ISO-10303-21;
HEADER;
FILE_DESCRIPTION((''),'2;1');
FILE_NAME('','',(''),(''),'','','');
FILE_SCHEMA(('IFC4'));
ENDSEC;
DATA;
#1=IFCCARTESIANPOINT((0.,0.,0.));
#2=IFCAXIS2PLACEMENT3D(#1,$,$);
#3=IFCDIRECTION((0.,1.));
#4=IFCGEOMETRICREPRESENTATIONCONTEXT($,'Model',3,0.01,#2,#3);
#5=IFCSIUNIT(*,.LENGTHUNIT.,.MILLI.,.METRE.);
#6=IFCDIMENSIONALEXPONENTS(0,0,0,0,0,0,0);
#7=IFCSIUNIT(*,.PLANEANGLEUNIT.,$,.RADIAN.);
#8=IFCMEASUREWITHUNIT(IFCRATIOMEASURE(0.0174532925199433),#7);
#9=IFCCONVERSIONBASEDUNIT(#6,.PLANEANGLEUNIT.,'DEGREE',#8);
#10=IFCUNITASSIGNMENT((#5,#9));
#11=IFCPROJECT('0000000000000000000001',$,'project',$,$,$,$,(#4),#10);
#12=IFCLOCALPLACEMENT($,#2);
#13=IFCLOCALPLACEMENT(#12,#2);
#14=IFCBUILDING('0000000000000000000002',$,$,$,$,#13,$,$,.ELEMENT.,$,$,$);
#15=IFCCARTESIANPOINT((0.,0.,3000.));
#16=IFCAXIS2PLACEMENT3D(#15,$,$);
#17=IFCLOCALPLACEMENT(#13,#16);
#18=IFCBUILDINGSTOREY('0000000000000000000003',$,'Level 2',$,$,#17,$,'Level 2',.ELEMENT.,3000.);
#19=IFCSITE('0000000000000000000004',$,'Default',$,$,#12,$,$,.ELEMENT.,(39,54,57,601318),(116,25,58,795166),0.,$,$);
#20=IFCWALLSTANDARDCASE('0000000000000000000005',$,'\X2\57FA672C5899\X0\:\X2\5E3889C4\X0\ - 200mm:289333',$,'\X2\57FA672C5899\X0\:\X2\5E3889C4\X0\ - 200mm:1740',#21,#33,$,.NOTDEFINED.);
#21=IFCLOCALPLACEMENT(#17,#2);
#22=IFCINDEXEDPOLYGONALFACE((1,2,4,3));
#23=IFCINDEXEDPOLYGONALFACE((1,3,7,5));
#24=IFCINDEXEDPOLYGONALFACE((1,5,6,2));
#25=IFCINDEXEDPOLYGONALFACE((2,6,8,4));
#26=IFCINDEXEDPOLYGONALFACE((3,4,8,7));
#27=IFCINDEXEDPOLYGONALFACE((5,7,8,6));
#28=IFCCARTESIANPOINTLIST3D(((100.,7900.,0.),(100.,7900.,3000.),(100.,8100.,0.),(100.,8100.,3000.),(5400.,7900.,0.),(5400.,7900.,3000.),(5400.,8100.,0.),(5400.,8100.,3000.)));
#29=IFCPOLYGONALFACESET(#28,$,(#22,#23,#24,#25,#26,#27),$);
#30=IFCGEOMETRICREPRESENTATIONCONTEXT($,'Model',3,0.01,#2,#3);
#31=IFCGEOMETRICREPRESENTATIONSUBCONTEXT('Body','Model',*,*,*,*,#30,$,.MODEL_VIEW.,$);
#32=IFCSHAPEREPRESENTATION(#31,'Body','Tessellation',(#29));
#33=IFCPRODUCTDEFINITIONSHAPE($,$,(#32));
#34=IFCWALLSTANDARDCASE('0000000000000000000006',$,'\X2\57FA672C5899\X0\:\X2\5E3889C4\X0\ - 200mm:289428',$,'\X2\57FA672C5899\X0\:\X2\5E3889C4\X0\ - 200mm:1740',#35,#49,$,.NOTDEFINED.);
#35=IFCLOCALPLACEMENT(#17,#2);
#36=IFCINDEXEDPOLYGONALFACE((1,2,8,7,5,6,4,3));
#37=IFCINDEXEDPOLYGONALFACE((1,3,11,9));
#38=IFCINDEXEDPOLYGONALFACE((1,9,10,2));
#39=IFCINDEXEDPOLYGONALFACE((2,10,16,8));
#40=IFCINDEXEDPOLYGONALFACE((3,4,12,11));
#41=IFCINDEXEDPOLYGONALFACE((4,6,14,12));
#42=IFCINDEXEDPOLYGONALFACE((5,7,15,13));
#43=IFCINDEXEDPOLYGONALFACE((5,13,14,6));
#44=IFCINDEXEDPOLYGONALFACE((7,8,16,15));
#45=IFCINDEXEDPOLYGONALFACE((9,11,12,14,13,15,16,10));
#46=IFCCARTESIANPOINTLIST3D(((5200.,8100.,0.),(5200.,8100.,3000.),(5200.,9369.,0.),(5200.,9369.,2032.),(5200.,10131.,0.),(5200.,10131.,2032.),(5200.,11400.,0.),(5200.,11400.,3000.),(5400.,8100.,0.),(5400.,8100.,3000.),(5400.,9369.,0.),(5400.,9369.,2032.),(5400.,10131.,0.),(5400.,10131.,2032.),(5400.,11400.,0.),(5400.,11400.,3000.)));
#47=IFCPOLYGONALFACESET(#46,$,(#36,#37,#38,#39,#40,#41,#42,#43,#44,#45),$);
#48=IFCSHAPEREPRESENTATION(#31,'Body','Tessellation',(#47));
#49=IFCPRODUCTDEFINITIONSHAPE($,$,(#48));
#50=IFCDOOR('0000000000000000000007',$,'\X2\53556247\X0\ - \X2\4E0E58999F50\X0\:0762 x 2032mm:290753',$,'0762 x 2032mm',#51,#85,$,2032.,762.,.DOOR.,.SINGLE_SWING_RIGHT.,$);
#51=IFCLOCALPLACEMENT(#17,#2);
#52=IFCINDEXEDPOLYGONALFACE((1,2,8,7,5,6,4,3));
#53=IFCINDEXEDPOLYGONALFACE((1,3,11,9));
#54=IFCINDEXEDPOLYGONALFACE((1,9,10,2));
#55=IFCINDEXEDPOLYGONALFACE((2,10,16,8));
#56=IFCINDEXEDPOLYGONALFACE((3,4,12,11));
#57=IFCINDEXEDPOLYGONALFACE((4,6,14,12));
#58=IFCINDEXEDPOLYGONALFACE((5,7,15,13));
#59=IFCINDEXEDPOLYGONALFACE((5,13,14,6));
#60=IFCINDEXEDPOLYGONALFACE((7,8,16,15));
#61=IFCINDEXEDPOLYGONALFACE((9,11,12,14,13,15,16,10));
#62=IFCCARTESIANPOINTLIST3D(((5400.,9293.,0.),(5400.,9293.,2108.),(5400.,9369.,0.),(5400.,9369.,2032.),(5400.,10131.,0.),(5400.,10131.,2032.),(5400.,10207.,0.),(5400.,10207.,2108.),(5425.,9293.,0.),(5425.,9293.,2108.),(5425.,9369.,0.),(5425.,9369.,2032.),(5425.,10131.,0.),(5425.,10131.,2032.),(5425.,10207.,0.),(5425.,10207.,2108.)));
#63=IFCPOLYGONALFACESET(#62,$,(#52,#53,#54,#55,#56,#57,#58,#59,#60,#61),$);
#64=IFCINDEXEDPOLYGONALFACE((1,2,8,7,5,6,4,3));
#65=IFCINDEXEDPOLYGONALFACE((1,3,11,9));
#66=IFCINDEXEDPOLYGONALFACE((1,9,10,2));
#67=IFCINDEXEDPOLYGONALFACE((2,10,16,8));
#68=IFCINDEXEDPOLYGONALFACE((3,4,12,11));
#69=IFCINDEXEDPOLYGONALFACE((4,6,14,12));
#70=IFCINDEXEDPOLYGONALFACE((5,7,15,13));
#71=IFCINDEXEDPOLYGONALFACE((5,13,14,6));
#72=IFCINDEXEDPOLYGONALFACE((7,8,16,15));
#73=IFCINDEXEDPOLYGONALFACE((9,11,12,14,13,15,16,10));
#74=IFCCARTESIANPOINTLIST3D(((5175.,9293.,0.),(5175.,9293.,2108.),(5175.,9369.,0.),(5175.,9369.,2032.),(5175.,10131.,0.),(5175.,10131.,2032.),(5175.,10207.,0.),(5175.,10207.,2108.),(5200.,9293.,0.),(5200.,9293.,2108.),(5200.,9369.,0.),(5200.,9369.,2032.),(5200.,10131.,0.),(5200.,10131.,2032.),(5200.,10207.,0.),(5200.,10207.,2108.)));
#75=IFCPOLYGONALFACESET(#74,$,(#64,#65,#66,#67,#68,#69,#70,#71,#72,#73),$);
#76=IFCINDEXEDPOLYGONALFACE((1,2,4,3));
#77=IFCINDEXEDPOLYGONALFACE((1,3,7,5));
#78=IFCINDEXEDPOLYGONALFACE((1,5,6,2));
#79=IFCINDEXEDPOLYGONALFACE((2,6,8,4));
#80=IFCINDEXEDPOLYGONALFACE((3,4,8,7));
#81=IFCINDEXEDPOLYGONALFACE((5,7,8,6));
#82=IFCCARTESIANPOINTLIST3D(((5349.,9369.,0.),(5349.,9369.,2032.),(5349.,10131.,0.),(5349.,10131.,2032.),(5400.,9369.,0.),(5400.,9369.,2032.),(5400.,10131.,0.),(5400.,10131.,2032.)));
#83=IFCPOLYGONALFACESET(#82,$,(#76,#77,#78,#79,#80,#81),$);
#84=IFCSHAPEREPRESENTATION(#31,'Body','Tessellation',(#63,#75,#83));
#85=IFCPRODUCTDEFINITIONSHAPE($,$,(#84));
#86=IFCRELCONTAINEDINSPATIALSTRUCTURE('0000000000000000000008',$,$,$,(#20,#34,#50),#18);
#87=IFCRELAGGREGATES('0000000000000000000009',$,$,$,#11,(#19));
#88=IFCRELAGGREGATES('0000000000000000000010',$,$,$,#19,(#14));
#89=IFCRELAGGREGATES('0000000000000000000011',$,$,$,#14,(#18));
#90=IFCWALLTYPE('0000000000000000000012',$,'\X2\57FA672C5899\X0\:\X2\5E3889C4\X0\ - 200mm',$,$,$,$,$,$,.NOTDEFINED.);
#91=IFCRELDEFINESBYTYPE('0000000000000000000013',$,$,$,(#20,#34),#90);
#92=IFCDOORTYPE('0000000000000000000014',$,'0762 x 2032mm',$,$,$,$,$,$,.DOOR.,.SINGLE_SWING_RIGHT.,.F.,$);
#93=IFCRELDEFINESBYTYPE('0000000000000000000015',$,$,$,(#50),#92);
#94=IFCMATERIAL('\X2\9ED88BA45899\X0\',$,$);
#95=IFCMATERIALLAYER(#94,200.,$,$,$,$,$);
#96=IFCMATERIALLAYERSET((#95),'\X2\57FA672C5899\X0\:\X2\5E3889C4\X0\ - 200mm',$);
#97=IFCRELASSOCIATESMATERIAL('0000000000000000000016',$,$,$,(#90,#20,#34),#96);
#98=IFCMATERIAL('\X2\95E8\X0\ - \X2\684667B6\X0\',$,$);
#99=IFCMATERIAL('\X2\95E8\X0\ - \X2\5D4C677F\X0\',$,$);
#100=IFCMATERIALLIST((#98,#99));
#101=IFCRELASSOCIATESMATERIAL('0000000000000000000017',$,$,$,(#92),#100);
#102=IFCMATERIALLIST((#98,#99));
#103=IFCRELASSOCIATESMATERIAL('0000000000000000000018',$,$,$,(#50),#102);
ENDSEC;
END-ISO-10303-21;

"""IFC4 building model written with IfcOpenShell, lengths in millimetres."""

from ifc_helpers import new_model, entity, si_unit, converted_unit, direction, frame, frame_2d, origin, origin_2d_with_axis, place, context, subcontext, project, spatial, polyline, rectangle, outline, extrude, source, transform, mapped, material, material_list, layer, layer_set, layer_usage, type_object, type_shapes, element, fill, save


model = new_model("IFC4")

# Units and contexts
model_context_1 = context("Model", 3, precision=0.01, world=origin(), true_north=direction((0.0, 1.0)))
model_context_2 = context("Model", 3, precision=0.01, world=origin(), true_north=direction((0.0, 1.0)))
body_context = subcontext(model_context_2, "Body", "Model", "MODEL_VIEW")
ifc_project = project(units=[si_unit("LENGTHUNIT", "METRE", prefix="MILLI"), converted_unit("PLANEANGLEUNIT", "DEGREE", entity("IfcRatioMeasure", 0.0174532925199433), si_unit("PLANEANGLEUNIT", "RADIAN"), dimensions=[0, 0, 0, 0, 0, 0, 0])], contexts=[model_context_1])

# Site, building, storey
site_placement = place(None, origin())
site = spatial("IfcSite", under=ifc_project, at=site_placement, Name="Default", CompositionType="ELEMENT", RefLatitude=(39, 54, 57, 601318), RefLongitude=(116, 25, 58, 795166), RefElevation=0.0)
building_placement = place(site_placement, origin())
building = spatial("IfcBuilding", under=site, at=building_placement, CompositionType="ELEMENT")
storey_placement = place(building_placement, frame((0.0, 0.0, 3000.0)))
storey = spatial("IfcBuildingStorey", under=building, at=storey_placement, Name="Level 2", LongName="Level 2", CompositionType="ELEMENT", Elevation=3000.0)

# Shared definitions
ifc_material_1 = material(Name="默认墙")
ifc_layer_1 = layer(ifc_material_1, 200.0)
ifc_layer_set_1 = layer_set([ifc_layer_1], Name="基本墙:常规 - 200mm")
wall_type = type_object("IfcWallType", Name="基本墙:常规 - 200mm", PredefinedType="NOTDEFINED", material=ifc_layer_set_1)

# Wall
ifc_layer_usage_1 = layer_usage(ifc_layer_set_1, "AXIS2", "NEGATIVE", 100.0)
wall_1_placement = place(storey_placement, frame((100.0, 8000.0, 0.0)))
element("IfcWallStandardCase", 1, at=wall_1_placement, inside=storey, type_object=wall_type, material=ifc_layer_usage_1, Name="基本墙:常规 - 200mm:289333", ObjectType="基本墙:常规 - 200mm:1740", PredefinedType="NOTDEFINED", context=body_context, shape_type="SweptSolid", body=[
    extrude(rectangle(XDim=5300.0, YDim=200.0, at=frame_2d((2650.0, 0.0), x_axis=(-1.0, 0.0))), origin(), (0.0, 0.0, 1.0), 3000.0),
])

# Wall, opening, door
ifc_layer_usage_2 = layer_usage(ifc_layer_set_1, "AXIS2", "NEGATIVE", 100.0)
wall_2_placement = place(storey_placement, frame((5300.0, 8100.0, 0.0), z_axis=(0.0, 0.0, 1.0), x_axis=(0.0, 1.0, 0.0)))
wall_2 = element("IfcWallStandardCase", 2, at=wall_2_placement, inside=storey, type_object=wall_type, material=ifc_layer_usage_2, Name="基本墙:常规 - 200mm:289428", ObjectType="基本墙:常规 - 200mm:1740", PredefinedType="NOTDEFINED", context=body_context, shape_type="SweptSolid", body=[
    extrude(rectangle(XDim=3300.0, YDim=200.0, at=frame_2d((1650.0, 0.0), x_axis=(-1.0, 0.0))), origin(), (0.0, 0.0, 1.0), 3000.0),
])
opening_1_placement = place(wall_2_placement, frame((2031.0, 100.0, 0.0)))
opening_1 = element("IfcOpeningElement", 3, at=opening_1_placement, cuts=wall_2, ObjectType="Opening", PredefinedType="OPENING", context=body_context, shape_type="SweptSolid", body=[
    extrude(rectangle(XDim=762.0, YDim=2032.0, at=frame_2d((1016.0, 381.0), x_axis=(0.0, 1.0))), frame((0.0, 0.0, 0.0), z_axis=(0.0, -1.0, 0.0), x_axis=(0.0, 0.0, 1.0)), (0.0, 0.0, 1.0), 200.0),
])
ifc_material_2 = material(Name="门 - 框架")
ifc_material_3 = material(Name="门 - 嵌板")
ifc_material_list_1 = material_list([ifc_material_2, ifc_material_3])
ifc_material_list_2 = material_list([ifc_material_2, ifc_material_3])
door_type = type_object("IfcDoorType", Name="0762 x 2032mm", OperationType="SINGLE_SWING_RIGHT", ParameterTakesPrecedence=False, PredefinedType="DOOR", material=ifc_material_list_2)
shared_shape_1 = source(origin(), body_context, "Body", "SweptSolid", [
    extrude(outline(polyline([(-457.0, -1073.0), (457.0, -1073.0), (457.0, 1035.0), (381.0, 1035.0), (381.0, -997.0), (-381.0, -997.0), (-381.0, 1035.0), (-457.0, 1035.0), (-457.0, -1073.0)])), frame((381.0, 200.0, 1035.0), z_axis=(0.0, 1.0, 0.0), x_axis=(1.0, 0.0, 0.0)), (0.0, 0.0, 1.0), 25.0),
    extrude(outline(polyline([(-1073.0, -457.0), (1035.0, -457.0), (1035.0, -381.0), (-997.0, -381.0), (-997.0, 381.0), (1035.0, 381.0), (1035.0, 457.0), (-1073.0, 457.0), (-1073.0, -457.0)])), frame((381.0, -25.0, 1035.0), z_axis=(0.0, 1.0, 0.0), x_axis=(0.0, 0.0, -1.0)), (0.0, 0.0, 1.0), 25.0),
    extrude(rectangle(XDim=51.0, YDim=762.0, at=origin_2d_with_axis()), frame((381.0, 174.5, 0.0), z_axis=(0.0, 0.0, 1.0), x_axis=(0.0, 1.0, 0.0)), (0.0, 0.0, 1.0), 2032.0),
])
type_shapes(door_type, [shared_shape_1])
door_placement = place(opening_1_placement, frame((0.0, 0.0, 0.0), z_axis=(0.0, 0.0, 1.0), x_axis=(-1.0, 0.0, 0.0)))
door = element("IfcDoor", 4, at=door_placement, inside=storey, type_object=door_type, material=ifc_material_list_1, Name="单扇 - 与墙齐:0762 x 2032mm:290753", ObjectType="0762 x 2032mm", OperationType="SINGLE_SWING_RIGHT", OverallHeight=2032.0, OverallWidth=762.0, PredefinedType="DOOR", context=body_context, shape_type="MappedRepresentation", body=[
    mapped(shared_shape_1, transform((0.0, 0.0, 0.0), scale=1.0)),
])
fill(opening_1, door)

save(model, "model.ifc")
